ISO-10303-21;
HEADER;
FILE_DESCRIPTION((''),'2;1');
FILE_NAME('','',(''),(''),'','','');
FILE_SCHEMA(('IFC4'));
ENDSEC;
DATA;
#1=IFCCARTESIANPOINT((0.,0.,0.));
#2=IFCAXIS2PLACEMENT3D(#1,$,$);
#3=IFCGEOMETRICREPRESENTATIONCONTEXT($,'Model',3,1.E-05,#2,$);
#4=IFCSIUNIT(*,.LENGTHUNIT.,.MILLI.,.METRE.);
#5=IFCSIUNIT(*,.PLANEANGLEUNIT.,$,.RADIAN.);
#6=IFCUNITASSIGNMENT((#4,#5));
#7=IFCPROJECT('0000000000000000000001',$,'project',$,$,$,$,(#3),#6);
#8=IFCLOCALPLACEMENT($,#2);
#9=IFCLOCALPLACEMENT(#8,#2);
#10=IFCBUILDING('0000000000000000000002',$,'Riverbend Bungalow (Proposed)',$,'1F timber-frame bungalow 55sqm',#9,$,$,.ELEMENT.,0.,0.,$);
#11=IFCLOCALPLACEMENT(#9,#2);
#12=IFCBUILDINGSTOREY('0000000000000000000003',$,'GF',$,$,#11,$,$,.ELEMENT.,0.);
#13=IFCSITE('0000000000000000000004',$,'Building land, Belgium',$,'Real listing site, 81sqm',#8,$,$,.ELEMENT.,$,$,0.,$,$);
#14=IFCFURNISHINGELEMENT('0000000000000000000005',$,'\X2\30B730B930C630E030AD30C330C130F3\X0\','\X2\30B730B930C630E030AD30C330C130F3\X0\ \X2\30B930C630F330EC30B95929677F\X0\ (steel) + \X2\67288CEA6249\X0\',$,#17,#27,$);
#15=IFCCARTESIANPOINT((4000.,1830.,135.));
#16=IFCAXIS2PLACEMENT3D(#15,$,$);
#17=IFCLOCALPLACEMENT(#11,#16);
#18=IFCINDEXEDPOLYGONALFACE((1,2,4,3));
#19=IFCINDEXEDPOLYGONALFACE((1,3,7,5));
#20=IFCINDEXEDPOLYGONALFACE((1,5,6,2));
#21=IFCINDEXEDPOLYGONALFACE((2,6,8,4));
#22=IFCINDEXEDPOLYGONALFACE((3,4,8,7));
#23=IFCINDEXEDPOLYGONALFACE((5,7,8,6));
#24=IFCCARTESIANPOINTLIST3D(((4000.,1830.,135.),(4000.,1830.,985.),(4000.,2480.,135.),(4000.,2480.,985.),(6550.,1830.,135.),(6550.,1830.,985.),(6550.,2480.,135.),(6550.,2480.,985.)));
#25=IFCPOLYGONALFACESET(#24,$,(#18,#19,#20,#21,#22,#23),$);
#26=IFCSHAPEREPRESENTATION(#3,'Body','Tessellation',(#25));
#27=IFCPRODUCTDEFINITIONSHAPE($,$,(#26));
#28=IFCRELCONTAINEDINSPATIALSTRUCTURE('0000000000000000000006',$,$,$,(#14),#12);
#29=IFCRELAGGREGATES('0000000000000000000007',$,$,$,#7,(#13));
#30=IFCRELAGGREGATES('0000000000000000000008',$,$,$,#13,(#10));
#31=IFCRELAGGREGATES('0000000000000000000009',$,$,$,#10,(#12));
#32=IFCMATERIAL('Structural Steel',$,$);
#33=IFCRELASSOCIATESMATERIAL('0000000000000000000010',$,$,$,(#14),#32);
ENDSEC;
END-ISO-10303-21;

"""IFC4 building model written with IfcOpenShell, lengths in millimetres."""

from ifc_helpers import new_model, si_unit, frame, frame_2d, origin, place, context, project, spatial, rectangle, extrude, material, element, save


model = new_model("IFC4")

# Units and contexts
model_context = context("Model", 3, precision=1e-05, world=origin())
ifc_project = project(units=[si_unit("LENGTHUNIT", "METRE", prefix="MILLI"), si_unit("PLANEANGLEUNIT", "RADIAN")], contexts=[model_context])

# Site, building, storey
site_placement = place(None, origin())
site = spatial("IfcSite", under=ifc_project, at=site_placement, Name="Building land, Belgium", ObjectType="Real listing site, 81sqm", CompositionType="ELEMENT", RefElevation=0.0)
building_placement = place(site_placement, origin())
building = spatial("IfcBuilding", under=site, at=building_placement, Name="Riverbend Bungalow (Proposed)", ObjectType="1F timber-frame bungalow 55sqm", CompositionType="ELEMENT", ElevationOfRefHeight=0.0, ElevationOfTerrain=0.0)
storey_placement = place(building_placement, origin())
storey = spatial("IfcBuildingStorey", under=building, at=storey_placement, Name="GF", CompositionType="ELEMENT", Elevation=0.0)

# Furnishing element
ifc_material_1 = material(Name="Structural Steel")
furnishing_1_placement = place(storey_placement, frame((4000.0, 1830.0, 135.0)))
element("IfcFurnishingElement", 1, at=furnishing_1_placement, inside=storey, material=ifc_material_1, Name="システムキッチン", Description="システムキッチン ステンレス天板 (steel) + 木質扉", context=model_context, shape_type="SweptSolid", body=[
    extrude(rectangle(XDim=2550.0, YDim=650.0, at=frame_2d((1275.0, 325.0))), frame((4000.0, 1830.0, 135.0)), (0.0, 0.0, 1.0), 850.0),
])

save(model, "model.ifc")
